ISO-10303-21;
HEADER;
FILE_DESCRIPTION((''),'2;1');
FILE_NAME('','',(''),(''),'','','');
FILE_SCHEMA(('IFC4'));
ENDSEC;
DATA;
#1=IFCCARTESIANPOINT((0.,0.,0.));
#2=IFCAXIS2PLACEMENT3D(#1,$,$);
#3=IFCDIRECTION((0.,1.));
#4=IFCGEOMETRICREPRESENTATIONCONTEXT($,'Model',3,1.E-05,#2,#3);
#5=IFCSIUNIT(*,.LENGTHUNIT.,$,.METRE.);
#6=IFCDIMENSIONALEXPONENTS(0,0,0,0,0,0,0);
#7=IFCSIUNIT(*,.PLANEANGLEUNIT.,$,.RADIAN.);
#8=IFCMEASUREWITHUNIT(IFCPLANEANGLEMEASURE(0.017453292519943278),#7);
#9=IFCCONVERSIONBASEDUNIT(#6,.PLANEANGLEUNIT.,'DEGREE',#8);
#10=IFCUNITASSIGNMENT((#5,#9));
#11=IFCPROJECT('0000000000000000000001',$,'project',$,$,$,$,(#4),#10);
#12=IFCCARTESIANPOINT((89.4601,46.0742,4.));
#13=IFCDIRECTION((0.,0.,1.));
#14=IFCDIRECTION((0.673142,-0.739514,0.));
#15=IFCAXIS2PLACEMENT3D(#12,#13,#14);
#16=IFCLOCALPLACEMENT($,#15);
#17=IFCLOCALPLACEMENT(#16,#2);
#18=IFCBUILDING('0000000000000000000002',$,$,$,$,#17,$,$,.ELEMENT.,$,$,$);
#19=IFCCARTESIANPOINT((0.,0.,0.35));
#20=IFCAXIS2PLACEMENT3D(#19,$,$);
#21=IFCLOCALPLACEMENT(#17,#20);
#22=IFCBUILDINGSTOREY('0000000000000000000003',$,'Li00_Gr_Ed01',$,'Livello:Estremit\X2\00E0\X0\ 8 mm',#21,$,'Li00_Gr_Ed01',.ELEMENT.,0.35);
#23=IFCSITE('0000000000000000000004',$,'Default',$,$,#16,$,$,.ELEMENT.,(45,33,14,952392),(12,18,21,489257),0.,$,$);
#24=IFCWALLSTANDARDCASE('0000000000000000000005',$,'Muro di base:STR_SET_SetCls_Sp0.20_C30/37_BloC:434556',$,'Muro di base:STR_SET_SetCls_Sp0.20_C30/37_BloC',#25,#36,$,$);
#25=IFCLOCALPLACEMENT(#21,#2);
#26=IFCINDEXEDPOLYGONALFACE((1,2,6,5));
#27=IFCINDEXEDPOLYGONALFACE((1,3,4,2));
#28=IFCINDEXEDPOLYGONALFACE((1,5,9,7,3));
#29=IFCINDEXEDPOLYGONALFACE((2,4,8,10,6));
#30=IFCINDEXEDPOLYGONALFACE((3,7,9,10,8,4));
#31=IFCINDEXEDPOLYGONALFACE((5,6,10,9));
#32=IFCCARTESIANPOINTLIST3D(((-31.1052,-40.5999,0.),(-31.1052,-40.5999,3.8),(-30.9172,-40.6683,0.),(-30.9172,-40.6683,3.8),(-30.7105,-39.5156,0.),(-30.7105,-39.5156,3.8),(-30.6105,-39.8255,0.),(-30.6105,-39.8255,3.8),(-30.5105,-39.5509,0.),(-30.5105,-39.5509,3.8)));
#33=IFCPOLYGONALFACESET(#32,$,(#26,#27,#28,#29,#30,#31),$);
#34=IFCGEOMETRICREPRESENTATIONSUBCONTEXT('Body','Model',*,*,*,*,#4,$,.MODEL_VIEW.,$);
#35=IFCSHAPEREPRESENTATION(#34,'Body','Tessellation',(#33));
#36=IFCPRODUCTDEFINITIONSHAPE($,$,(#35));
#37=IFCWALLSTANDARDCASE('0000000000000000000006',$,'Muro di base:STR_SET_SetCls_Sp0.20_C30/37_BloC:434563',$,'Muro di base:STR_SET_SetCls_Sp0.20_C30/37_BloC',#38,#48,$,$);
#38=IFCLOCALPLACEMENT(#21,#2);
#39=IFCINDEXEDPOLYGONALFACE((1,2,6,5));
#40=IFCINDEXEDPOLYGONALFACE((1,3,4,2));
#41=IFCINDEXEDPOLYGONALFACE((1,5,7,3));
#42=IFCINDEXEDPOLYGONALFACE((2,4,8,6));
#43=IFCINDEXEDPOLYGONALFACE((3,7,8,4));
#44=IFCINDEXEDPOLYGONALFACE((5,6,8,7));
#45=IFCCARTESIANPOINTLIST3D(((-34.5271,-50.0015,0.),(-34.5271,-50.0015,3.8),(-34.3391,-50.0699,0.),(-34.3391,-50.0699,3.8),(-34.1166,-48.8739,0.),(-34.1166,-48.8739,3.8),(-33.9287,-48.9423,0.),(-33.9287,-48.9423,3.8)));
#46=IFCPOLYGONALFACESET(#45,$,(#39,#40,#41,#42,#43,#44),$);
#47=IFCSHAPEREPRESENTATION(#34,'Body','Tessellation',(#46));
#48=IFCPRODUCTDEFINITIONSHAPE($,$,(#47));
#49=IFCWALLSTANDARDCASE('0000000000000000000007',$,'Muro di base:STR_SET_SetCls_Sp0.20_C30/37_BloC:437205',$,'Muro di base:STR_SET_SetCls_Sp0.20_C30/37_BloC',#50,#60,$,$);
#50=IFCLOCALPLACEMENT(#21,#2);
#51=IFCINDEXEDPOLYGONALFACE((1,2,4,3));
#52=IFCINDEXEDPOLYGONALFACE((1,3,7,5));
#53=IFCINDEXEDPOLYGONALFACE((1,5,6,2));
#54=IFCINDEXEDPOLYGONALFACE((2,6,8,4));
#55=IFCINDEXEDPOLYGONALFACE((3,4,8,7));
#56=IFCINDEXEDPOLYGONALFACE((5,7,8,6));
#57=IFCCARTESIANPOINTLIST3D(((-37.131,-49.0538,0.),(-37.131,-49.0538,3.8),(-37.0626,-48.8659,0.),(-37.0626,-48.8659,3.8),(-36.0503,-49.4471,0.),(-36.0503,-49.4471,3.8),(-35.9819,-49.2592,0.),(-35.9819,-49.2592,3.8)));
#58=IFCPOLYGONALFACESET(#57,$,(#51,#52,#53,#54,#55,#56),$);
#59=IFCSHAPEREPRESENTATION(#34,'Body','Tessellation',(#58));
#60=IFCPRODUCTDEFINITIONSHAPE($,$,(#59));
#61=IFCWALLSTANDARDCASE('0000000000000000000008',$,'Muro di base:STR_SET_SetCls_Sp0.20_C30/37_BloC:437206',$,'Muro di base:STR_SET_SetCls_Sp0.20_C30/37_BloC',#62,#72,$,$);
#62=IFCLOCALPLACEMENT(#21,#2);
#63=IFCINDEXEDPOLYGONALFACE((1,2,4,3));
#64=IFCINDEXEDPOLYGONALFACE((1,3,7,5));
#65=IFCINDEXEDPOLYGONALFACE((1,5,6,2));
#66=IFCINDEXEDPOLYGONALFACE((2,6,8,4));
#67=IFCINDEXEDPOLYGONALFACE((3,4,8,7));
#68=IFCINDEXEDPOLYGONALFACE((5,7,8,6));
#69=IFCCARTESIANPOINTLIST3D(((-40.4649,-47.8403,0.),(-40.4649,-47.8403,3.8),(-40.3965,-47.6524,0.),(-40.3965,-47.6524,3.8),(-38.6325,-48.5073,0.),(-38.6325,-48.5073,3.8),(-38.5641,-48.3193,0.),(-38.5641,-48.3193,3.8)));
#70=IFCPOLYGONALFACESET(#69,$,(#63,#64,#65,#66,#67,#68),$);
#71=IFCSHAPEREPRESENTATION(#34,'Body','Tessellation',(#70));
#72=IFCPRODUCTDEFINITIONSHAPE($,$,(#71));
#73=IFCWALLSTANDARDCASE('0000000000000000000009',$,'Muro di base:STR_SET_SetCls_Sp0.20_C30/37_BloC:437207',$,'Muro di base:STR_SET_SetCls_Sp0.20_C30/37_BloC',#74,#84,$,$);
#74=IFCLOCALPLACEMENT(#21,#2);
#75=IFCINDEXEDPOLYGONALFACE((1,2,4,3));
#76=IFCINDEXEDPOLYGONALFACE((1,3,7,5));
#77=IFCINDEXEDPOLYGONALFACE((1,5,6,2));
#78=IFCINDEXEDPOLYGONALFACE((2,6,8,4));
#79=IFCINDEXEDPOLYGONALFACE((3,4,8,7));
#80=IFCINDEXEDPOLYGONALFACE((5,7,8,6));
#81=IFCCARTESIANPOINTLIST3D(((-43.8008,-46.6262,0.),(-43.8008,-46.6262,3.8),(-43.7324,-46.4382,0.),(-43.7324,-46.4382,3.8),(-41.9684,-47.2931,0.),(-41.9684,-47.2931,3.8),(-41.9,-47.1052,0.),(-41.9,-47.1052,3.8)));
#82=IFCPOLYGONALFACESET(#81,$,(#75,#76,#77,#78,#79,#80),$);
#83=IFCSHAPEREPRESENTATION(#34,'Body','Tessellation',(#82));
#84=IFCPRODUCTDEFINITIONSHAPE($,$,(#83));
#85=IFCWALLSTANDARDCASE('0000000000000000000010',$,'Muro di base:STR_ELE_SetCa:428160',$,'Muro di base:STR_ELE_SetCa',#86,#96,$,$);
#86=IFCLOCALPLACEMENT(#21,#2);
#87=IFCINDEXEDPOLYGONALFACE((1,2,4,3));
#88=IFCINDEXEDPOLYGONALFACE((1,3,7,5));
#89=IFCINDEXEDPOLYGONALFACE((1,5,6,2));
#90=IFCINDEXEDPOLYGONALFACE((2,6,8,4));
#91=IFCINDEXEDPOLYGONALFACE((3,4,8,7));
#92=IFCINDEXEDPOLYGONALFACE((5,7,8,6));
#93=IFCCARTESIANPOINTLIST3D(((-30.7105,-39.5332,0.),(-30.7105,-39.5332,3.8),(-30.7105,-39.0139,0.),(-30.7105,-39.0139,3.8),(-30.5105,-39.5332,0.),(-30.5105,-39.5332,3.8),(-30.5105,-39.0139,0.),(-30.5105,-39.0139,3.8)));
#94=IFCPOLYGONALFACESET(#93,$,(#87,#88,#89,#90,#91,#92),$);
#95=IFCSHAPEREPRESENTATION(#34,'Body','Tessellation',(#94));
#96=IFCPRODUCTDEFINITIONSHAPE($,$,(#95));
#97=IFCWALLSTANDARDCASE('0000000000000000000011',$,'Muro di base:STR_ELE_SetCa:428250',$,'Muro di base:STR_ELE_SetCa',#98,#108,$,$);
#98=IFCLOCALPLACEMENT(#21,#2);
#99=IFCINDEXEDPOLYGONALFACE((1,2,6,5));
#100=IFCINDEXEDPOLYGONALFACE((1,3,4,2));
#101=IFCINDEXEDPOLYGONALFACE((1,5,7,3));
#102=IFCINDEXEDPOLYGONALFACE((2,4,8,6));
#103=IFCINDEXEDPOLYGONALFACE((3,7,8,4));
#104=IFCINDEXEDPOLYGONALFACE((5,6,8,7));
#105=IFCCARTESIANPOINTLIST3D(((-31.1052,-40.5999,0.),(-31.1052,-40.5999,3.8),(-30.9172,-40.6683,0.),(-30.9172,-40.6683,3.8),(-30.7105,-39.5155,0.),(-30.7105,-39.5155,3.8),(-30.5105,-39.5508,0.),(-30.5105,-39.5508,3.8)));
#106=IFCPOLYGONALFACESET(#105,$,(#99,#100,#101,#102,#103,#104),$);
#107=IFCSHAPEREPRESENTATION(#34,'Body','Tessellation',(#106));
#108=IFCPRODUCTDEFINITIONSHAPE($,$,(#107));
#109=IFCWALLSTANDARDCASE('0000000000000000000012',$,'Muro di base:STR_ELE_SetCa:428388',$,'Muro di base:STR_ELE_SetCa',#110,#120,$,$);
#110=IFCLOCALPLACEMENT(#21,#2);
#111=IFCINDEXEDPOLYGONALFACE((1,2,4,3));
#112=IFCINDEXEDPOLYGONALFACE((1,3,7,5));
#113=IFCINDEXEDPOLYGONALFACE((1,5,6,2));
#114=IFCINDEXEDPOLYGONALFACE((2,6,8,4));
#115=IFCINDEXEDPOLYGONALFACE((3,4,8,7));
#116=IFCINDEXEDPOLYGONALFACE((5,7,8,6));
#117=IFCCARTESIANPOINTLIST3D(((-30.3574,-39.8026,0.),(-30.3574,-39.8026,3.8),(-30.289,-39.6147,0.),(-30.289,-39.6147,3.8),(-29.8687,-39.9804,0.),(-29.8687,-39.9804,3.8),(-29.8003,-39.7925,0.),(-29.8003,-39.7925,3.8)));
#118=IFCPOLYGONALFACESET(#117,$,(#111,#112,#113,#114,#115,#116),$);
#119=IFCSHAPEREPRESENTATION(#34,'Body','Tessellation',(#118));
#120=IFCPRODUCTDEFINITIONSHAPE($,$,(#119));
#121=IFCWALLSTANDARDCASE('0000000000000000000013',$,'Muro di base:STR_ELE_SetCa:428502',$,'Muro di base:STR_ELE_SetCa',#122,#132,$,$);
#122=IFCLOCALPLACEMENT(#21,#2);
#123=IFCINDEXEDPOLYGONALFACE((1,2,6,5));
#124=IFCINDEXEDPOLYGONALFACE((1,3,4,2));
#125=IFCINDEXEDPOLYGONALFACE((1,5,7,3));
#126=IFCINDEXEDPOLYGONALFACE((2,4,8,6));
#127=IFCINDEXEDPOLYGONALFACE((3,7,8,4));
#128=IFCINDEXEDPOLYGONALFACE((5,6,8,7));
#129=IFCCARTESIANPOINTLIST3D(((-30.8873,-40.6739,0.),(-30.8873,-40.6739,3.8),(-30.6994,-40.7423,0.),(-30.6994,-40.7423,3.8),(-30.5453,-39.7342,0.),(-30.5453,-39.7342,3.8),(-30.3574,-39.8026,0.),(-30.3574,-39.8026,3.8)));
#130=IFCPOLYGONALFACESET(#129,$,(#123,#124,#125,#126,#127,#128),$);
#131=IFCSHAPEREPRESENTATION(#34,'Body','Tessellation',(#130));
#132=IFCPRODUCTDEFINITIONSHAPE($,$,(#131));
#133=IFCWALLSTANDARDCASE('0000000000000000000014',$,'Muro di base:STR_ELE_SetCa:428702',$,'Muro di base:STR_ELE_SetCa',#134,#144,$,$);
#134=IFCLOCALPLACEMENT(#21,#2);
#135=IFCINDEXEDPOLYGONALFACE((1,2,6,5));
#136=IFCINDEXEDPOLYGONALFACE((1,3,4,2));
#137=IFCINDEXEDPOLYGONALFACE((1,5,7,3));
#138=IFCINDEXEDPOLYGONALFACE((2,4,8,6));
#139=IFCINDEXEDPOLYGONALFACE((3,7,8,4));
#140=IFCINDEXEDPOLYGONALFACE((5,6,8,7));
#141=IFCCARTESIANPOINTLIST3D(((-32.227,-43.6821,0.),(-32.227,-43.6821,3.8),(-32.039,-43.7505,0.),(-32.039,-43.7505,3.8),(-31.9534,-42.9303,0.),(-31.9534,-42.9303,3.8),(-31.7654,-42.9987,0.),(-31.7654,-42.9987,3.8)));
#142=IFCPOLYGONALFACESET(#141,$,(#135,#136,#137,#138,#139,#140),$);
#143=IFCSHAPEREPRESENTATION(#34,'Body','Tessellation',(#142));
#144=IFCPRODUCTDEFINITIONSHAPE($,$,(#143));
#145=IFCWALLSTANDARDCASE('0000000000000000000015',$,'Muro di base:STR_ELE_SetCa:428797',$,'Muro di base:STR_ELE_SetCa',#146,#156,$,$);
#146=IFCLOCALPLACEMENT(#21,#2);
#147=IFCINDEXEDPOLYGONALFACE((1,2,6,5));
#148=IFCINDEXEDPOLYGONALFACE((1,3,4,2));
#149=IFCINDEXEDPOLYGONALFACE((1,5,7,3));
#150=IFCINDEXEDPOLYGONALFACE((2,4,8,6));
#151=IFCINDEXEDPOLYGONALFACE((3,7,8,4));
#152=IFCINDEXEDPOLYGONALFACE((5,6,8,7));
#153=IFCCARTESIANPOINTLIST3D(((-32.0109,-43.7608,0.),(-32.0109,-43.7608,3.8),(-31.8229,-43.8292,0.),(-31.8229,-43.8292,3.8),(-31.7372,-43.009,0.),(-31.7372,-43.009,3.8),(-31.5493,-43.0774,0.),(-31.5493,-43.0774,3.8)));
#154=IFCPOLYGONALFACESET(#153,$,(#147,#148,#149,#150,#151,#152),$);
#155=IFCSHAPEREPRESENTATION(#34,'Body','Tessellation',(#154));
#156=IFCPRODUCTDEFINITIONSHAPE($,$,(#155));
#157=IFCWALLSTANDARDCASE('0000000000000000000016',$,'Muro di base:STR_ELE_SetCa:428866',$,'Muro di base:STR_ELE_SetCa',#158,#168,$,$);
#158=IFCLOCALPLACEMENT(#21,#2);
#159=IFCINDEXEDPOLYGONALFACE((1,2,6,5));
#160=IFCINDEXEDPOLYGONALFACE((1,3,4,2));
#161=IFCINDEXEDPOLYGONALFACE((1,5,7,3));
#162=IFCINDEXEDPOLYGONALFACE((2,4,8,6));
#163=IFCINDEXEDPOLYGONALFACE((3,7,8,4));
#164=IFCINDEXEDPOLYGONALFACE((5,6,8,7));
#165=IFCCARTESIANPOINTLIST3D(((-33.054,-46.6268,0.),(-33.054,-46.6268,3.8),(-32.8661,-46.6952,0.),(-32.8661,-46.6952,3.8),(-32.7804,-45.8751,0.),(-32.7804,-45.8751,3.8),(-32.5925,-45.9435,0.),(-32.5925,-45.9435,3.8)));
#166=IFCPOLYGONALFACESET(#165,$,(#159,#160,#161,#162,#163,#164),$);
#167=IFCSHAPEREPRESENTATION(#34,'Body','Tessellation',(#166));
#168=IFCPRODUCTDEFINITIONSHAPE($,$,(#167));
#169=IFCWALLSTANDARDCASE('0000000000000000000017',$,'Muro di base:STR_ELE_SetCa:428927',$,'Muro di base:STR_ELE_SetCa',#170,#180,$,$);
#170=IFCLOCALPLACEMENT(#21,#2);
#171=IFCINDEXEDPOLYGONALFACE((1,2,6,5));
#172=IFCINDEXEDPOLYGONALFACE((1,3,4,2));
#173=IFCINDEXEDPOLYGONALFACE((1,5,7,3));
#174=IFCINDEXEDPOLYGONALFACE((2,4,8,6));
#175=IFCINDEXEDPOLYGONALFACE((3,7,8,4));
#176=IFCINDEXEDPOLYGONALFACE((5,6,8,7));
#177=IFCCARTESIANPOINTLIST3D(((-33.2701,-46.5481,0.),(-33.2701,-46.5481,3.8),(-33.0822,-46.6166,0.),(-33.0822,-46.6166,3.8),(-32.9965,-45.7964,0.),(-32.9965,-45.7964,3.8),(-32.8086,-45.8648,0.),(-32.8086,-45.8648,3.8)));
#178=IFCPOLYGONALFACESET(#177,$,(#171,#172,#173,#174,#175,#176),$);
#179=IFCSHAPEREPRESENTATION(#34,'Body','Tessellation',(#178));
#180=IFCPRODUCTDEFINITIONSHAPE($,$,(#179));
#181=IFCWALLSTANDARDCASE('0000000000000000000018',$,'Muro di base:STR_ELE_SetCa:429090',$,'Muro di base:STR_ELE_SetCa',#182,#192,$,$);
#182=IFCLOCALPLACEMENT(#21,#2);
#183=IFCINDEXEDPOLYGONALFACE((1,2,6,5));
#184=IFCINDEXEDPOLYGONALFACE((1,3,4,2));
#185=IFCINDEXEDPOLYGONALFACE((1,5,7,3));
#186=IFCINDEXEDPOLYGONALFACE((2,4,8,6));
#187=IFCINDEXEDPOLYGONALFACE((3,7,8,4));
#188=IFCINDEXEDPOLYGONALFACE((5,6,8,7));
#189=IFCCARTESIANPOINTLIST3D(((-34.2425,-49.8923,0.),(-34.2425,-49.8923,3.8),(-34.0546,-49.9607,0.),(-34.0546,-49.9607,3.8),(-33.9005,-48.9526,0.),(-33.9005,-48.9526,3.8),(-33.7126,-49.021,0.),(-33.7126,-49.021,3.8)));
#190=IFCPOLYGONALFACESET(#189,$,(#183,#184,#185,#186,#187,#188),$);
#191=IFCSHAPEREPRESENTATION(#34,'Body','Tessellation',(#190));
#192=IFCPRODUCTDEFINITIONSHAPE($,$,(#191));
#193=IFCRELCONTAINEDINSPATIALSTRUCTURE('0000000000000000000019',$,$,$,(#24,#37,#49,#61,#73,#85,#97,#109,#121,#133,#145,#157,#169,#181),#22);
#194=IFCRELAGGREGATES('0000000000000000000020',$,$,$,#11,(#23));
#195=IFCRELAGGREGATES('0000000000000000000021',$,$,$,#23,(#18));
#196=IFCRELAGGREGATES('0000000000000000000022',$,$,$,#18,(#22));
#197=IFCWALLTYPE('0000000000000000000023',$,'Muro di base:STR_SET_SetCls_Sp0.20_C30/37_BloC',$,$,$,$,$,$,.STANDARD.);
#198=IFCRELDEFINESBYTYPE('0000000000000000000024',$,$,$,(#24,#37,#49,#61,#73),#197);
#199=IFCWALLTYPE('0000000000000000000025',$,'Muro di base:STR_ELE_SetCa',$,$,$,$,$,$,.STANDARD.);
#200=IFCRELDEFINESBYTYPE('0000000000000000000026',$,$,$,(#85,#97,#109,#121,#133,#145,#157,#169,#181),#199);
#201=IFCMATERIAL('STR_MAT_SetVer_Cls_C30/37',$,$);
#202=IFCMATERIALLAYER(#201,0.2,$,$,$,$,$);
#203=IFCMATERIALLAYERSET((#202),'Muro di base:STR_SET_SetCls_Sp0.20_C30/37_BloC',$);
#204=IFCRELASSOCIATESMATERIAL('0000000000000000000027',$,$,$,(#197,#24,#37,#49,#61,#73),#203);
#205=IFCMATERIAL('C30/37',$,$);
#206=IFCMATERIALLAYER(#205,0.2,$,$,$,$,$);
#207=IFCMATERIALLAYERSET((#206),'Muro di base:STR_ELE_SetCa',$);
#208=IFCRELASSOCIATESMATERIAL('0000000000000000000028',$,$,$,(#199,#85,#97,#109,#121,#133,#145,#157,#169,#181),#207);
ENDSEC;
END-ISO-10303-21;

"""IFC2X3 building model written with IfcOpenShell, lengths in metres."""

from ifc_helpers import new_model, entity, si_unit, converted_unit, direction, frame, frame_2d, origin, place, context, subcontext, project, spatial, polyline, rectangle, outline, extrude, material, layer, layer_set, layer_usage, type_object, element, save


model = new_model("IFC2X3")

# Units and contexts
model_context = context("Model", 3, precision=1e-05, world=origin(), true_north=direction((0.0, 1.0)))
body_context = subcontext(model_context, "Body", "Model", "MODEL_VIEW")
ifc_project = project(units=[si_unit("LENGTHUNIT", "METRE"), converted_unit("PLANEANGLEUNIT", "DEGREE", entity("IfcPlaneAngleMeasure", 0.017453292519943278), si_unit("PLANEANGLEUNIT", "RADIAN"), dimensions=[0, 0, 0, 0, 0, 0, 0])], contexts=[model_context])

# Site, building, storey
site_placement = place(None, frame((89.4601, 46.0742, 4.0), z_axis=(0.0, 0.0, 1.0), x_axis=(0.673142, -0.739514, 0.0)))
site = spatial("IfcSite", under=ifc_project, at=site_placement, Name="Default", CompositionType="ELEMENT", RefLatitude=(45, 33, 14, 952392), RefLongitude=(12, 18, 21, 489257), RefElevation=0.0)
building_placement = place(site_placement, origin())
building = spatial("IfcBuilding", under=site, at=building_placement, CompositionType="ELEMENT")
storey_placement = place(building_placement, frame((0.0, 0.0, 0.35)))
storey = spatial("IfcBuildingStorey", under=building, at=storey_placement, Name="Li00_Gr_Ed01", ObjectType="Livello:Estremità 8 mm", LongName="Li00_Gr_Ed01", CompositionType="ELEMENT", Elevation=0.35)

# Walls
ifc_material_1 = material(Name="STR_MAT_SetVer_Cls_C30/37")
ifc_layer_1 = layer(ifc_material_1, 0.2)
ifc_layer_set_1 = layer_set([ifc_layer_1], Name="Muro di base:STR_SET_SetCls_Sp0.20_C30/37_BloC")
ifc_layer_usage_1 = layer_usage(ifc_layer_set_1, "AXIS2", "NEGATIVE", 0.1)
wall_type_1 = type_object("IfcWallType", Name="Muro di base:STR_SET_SetCls_Sp0.20_C30/37_BloC", PredefinedType="STANDARD", material=ifc_layer_set_1)
wall_1_placement = place(storey_placement, frame((-31.0112, -40.6341, 0.0), z_axis=(0.0, 0.0, 1.0), x_axis=(0.34202, 0.939693, 0.0)))
element("IfcWallStandardCase", 1, at=wall_1_placement, inside=storey, type_object=wall_type_1, material=ifc_layer_usage_1, Name="Muro di base:STR_SET_SetCls_Sp0.20_C30/37_BloC:434556", ObjectType="Muro di base:STR_SET_SetCls_Sp0.20_C30/37_BloC", context=body_context, shape_type="SweptSolid", body=[
    extrude(outline(polyline([(1.1891, -0.1), (1.1539, 0.1), (0.0, 0.1), (0.0, -0.1), (0.8969, -0.1), (1.1891, -0.1)])), origin(), (0.0, 0.0, 1.0), 3.8),
])
wall_2_placement = place(storey_placement, frame((-34.4331, -50.0357, 0.0), z_axis=(0.0, 0.0, 1.0), x_axis=(0.34202, 0.939693, 0.0)))
element("IfcWallStandardCase", 2, at=wall_2_placement, inside=storey, type_object=wall_type_1, material=ifc_layer_usage_1, Name="Muro di base:STR_SET_SetCls_Sp0.20_C30/37_BloC:434563", ObjectType="Muro di base:STR_SET_SetCls_Sp0.20_C30/37_BloC", context=body_context, shape_type="SweptSolid", body=[
    extrude(rectangle(XDim=1.2, YDim=0.2, at=frame_2d((0.6, 0.0), x_axis=(-1.0, 0.0))), origin(), (0.0, 0.0, 1.0), 3.8),
])
wall_3_placement = place(storey_placement, frame((-36.0161, -49.3531, 0.0), z_axis=(0.0, 0.0, 1.0), x_axis=(-0.939693, 0.34202, 0.0)))
element("IfcWallStandardCase", 3, at=wall_3_placement, inside=storey, type_object=wall_type_1, material=ifc_layer_usage_1, Name="Muro di base:STR_SET_SetCls_Sp0.20_C30/37_BloC:437205", ObjectType="Muro di base:STR_SET_SetCls_Sp0.20_C30/37_BloC", context=body_context, shape_type="SweptSolid", body=[
    extrude(rectangle(XDim=1.15, YDim=0.2, at=frame_2d((0.575, 0.0), x_axis=(-1.0, 0.0))), origin(), (0.0, 0.0, 1.0), 3.8),
])
wall_4_placement = place(storey_placement, frame((-38.5983, -48.4133, 0.0), z_axis=(0.0, 0.0, 1.0), x_axis=(-0.939693, 0.34202, 0.0)))
element("IfcWallStandardCase", 4, at=wall_4_placement, inside=storey, type_object=wall_type_1, material=ifc_layer_usage_1, Name="Muro di base:STR_SET_SetCls_Sp0.20_C30/37_BloC:437206", ObjectType="Muro di base:STR_SET_SetCls_Sp0.20_C30/37_BloC", context=body_context, shape_type="SweptSolid", body=[
    extrude(rectangle(XDim=1.95, YDim=0.2, at=frame_2d((0.975, 0.0), x_axis=(-1.0, 0.0))), origin(), (0.0, 0.0, 1.0), 3.8),
])
wall_5_placement = place(storey_placement, frame((-41.9342, -47.1991, 0.0), z_axis=(0.0, 0.0, 1.0), x_axis=(-0.939693, 0.34202, 0.0)))
element("IfcWallStandardCase", 5, at=wall_5_placement, inside=storey, type_object=wall_type_1, material=ifc_layer_usage_1, Name="Muro di base:STR_SET_SetCls_Sp0.20_C30/37_BloC:437207", ObjectType="Muro di base:STR_SET_SetCls_Sp0.20_C30/37_BloC", context=body_context, shape_type="SweptSolid", body=[
    extrude(rectangle(XDim=1.95, YDim=0.2, at=frame_2d((0.975, 0.0), x_axis=(-1.0, 0.0))), origin(), (0.0, 0.0, 1.0), 3.8),
])
ifc_material_2 = material(Name="C30/37")
ifc_layer_2 = layer(ifc_material_2, 0.2)
ifc_layer_set_2 = layer_set([ifc_layer_2], Name="Muro di base:STR_ELE_SetCa")
ifc_layer_usage_2 = layer_usage(ifc_layer_set_2, "AXIS2", "NEGATIVE", 0.1)
wall_type_2 = type_object("IfcWallType", Name="Muro di base:STR_ELE_SetCa", PredefinedType="STANDARD", material=ifc_layer_set_2)
wall_6_placement = place(storey_placement, frame((-30.6105, -39.0139, 0.0), z_axis=(0.0, 0.0, 1.0), x_axis=(0.0, -1.0, 0.0)))
element("IfcWallStandardCase", 6, at=wall_6_placement, inside=storey, type_object=wall_type_2, material=ifc_layer_usage_2, Name="Muro di base:STR_ELE_SetCa:428160", ObjectType="Muro di base:STR_ELE_SetCa", context=body_context, shape_type="SweptSolid", body=[
    extrude(rectangle(XDim=0.5194, YDim=0.2, at=frame_2d((0.2597, 0.0), x_axis=(-1.0, 0.0))), origin(), (0.0, 0.0, 1.0), 3.8),
])
wall_7_placement = place(storey_placement, frame((-31.0112, -40.6341, 0.0), z_axis=(0.0, 0.0, 1.0), x_axis=(0.342, 0.9397, 0.0)))
element("IfcWallStandardCase", 7, at=wall_7_placement, inside=storey, type_object=wall_type_2, material=ifc_layer_usage_2, Name="Muro di base:STR_ELE_SetCa:428250", ObjectType="Muro di base:STR_ELE_SetCa", context=body_context, shape_type="SweptSolid", body=[
    extrude(outline(polyline([(1.1892, -0.1), (1.154, 0.1), (0.0, 0.1), (0.0, -0.1), (1.1892, -0.1)])), origin(), (0.0, 0.0, 1.0), 3.8),
])
wall_8_placement = place(storey_placement, frame((-29.8345, -39.8865, 0.0), z_axis=(0.0, 0.0, 1.0), x_axis=(-0.939693, 0.34202, 0.0)))
element("IfcWallStandardCase", 8, at=wall_8_placement, inside=storey, type_object=wall_type_2, material=ifc_layer_usage_2, Name="Muro di base:STR_ELE_SetCa:428388", ObjectType="Muro di base:STR_ELE_SetCa", context=body_context, shape_type="SweptSolid", body=[
    extrude(rectangle(XDim=0.52, YDim=0.2, at=frame_2d((0.26, 0.0), x_axis=(-1.0, 0.0))), origin(), (0.0, 0.0, 1.0), 3.8),
])
wall_9_placement = place(storey_placement, frame((-30.7934, -40.7081, 0.0), z_axis=(0.0, 0.0, 1.0), x_axis=(0.342, 0.9397, 0.0)))
element("IfcWallStandardCase", 9, at=wall_9_placement, inside=storey, type_object=wall_type_2, material=ifc_layer_usage_2, Name="Muro di base:STR_ELE_SetCa:428502", ObjectType="Muro di base:STR_ELE_SetCa", context=body_context, shape_type="SweptSolid", body=[
    extrude(rectangle(XDim=1.0, YDim=0.2, at=frame_2d((0.5, 0.0), x_axis=(-1.0, 0.0))), origin(), (0.0, 0.0, 1.0), 3.8),
])
wall_10_placement = place(storey_placement, frame((-31.8594, -42.9645, 0.0), z_axis=(0.0, 0.0, 1.0), x_axis=(-0.34202, -0.939693, 0.0)))
element("IfcWallStandardCase", 10, at=wall_10_placement, inside=storey, type_object=wall_type_2, material=ifc_layer_usage_2, Name="Muro di base:STR_ELE_SetCa:428702", ObjectType="Muro di base:STR_ELE_SetCa", context=body_context, shape_type="SweptSolid", body=[
    extrude(rectangle(XDim=0.8, YDim=0.2, at=frame_2d((0.4, 0.0), x_axis=(-1.0, 0.0))), origin(), (0.0, 0.0, 1.0), 3.8),
])
wall_11_placement = place(storey_placement, frame((-31.6433, -43.0432, 0.0), z_axis=(0.0, 0.0, 1.0), x_axis=(-0.34202, -0.939693, 0.0)))
element("IfcWallStandardCase", 11, at=wall_11_placement, inside=storey, type_object=wall_type_2, material=ifc_layer_usage_2, Name="Muro di base:STR_ELE_SetCa:428797", ObjectType="Muro di base:STR_ELE_SetCa", context=body_context, shape_type="SweptSolid", body=[
    extrude(rectangle(XDim=0.8, YDim=0.2, at=frame_2d((0.4, 0.0), x_axis=(-1.0, 0.0))), origin(), (0.0, 0.0, 1.0), 3.8),
])
for number, where, z_axis, x_axis, name in (
    (12, (-32.96, -46.661, 0.0), (0.0, 0.0, 1.0), (0.34202, 0.939693, 0.0), "Muro di base:STR_ELE_SetCa:428866"),
    (13, (-32.9026, -45.8306, 0.0), (0.0, 0.0, 1.0), (-0.34202, -0.939693, 0.0), "Muro di base:STR_ELE_SetCa:428927"),
):
    element("IfcWallStandardCase", number, at=place(storey_placement, frame(where, z_axis=z_axis, x_axis=x_axis)), inside=storey, type_object=wall_type_2, material=ifc_layer_usage_2, Name=name, ObjectType="Muro di base:STR_ELE_SetCa", context=body_context, shape_type="SweptSolid", body=[
        extrude(rectangle(XDim=0.8, YDim=0.2, at=frame_2d((0.4, 0.0), x_axis=(-1.0, 0.0))), origin(), (0.0, 0.0, 1.0), 3.8),
    ])
wall_12_placement = place(storey_placement, frame((-33.8065, -48.9868, 0.0), z_axis=(0.0, 0.0, 1.0), x_axis=(-0.34202, -0.939693, 0.0)))
element("IfcWallStandardCase", 14, at=wall_12_placement, inside=storey, type_object=wall_type_2, material=ifc_layer_usage_2, Name="Muro di base:STR_ELE_SetCa:429090", ObjectType="Muro di base:STR_ELE_SetCa", context=body_context, shape_type="SweptSolid", body=[
    extrude(rectangle(XDim=1.0, YDim=0.2, at=frame_2d((0.5, 0.0), x_axis=(-1.0, 0.0))), origin(), (0.0, 0.0, 1.0), 3.8),
])

save(model, "model.ifc")
